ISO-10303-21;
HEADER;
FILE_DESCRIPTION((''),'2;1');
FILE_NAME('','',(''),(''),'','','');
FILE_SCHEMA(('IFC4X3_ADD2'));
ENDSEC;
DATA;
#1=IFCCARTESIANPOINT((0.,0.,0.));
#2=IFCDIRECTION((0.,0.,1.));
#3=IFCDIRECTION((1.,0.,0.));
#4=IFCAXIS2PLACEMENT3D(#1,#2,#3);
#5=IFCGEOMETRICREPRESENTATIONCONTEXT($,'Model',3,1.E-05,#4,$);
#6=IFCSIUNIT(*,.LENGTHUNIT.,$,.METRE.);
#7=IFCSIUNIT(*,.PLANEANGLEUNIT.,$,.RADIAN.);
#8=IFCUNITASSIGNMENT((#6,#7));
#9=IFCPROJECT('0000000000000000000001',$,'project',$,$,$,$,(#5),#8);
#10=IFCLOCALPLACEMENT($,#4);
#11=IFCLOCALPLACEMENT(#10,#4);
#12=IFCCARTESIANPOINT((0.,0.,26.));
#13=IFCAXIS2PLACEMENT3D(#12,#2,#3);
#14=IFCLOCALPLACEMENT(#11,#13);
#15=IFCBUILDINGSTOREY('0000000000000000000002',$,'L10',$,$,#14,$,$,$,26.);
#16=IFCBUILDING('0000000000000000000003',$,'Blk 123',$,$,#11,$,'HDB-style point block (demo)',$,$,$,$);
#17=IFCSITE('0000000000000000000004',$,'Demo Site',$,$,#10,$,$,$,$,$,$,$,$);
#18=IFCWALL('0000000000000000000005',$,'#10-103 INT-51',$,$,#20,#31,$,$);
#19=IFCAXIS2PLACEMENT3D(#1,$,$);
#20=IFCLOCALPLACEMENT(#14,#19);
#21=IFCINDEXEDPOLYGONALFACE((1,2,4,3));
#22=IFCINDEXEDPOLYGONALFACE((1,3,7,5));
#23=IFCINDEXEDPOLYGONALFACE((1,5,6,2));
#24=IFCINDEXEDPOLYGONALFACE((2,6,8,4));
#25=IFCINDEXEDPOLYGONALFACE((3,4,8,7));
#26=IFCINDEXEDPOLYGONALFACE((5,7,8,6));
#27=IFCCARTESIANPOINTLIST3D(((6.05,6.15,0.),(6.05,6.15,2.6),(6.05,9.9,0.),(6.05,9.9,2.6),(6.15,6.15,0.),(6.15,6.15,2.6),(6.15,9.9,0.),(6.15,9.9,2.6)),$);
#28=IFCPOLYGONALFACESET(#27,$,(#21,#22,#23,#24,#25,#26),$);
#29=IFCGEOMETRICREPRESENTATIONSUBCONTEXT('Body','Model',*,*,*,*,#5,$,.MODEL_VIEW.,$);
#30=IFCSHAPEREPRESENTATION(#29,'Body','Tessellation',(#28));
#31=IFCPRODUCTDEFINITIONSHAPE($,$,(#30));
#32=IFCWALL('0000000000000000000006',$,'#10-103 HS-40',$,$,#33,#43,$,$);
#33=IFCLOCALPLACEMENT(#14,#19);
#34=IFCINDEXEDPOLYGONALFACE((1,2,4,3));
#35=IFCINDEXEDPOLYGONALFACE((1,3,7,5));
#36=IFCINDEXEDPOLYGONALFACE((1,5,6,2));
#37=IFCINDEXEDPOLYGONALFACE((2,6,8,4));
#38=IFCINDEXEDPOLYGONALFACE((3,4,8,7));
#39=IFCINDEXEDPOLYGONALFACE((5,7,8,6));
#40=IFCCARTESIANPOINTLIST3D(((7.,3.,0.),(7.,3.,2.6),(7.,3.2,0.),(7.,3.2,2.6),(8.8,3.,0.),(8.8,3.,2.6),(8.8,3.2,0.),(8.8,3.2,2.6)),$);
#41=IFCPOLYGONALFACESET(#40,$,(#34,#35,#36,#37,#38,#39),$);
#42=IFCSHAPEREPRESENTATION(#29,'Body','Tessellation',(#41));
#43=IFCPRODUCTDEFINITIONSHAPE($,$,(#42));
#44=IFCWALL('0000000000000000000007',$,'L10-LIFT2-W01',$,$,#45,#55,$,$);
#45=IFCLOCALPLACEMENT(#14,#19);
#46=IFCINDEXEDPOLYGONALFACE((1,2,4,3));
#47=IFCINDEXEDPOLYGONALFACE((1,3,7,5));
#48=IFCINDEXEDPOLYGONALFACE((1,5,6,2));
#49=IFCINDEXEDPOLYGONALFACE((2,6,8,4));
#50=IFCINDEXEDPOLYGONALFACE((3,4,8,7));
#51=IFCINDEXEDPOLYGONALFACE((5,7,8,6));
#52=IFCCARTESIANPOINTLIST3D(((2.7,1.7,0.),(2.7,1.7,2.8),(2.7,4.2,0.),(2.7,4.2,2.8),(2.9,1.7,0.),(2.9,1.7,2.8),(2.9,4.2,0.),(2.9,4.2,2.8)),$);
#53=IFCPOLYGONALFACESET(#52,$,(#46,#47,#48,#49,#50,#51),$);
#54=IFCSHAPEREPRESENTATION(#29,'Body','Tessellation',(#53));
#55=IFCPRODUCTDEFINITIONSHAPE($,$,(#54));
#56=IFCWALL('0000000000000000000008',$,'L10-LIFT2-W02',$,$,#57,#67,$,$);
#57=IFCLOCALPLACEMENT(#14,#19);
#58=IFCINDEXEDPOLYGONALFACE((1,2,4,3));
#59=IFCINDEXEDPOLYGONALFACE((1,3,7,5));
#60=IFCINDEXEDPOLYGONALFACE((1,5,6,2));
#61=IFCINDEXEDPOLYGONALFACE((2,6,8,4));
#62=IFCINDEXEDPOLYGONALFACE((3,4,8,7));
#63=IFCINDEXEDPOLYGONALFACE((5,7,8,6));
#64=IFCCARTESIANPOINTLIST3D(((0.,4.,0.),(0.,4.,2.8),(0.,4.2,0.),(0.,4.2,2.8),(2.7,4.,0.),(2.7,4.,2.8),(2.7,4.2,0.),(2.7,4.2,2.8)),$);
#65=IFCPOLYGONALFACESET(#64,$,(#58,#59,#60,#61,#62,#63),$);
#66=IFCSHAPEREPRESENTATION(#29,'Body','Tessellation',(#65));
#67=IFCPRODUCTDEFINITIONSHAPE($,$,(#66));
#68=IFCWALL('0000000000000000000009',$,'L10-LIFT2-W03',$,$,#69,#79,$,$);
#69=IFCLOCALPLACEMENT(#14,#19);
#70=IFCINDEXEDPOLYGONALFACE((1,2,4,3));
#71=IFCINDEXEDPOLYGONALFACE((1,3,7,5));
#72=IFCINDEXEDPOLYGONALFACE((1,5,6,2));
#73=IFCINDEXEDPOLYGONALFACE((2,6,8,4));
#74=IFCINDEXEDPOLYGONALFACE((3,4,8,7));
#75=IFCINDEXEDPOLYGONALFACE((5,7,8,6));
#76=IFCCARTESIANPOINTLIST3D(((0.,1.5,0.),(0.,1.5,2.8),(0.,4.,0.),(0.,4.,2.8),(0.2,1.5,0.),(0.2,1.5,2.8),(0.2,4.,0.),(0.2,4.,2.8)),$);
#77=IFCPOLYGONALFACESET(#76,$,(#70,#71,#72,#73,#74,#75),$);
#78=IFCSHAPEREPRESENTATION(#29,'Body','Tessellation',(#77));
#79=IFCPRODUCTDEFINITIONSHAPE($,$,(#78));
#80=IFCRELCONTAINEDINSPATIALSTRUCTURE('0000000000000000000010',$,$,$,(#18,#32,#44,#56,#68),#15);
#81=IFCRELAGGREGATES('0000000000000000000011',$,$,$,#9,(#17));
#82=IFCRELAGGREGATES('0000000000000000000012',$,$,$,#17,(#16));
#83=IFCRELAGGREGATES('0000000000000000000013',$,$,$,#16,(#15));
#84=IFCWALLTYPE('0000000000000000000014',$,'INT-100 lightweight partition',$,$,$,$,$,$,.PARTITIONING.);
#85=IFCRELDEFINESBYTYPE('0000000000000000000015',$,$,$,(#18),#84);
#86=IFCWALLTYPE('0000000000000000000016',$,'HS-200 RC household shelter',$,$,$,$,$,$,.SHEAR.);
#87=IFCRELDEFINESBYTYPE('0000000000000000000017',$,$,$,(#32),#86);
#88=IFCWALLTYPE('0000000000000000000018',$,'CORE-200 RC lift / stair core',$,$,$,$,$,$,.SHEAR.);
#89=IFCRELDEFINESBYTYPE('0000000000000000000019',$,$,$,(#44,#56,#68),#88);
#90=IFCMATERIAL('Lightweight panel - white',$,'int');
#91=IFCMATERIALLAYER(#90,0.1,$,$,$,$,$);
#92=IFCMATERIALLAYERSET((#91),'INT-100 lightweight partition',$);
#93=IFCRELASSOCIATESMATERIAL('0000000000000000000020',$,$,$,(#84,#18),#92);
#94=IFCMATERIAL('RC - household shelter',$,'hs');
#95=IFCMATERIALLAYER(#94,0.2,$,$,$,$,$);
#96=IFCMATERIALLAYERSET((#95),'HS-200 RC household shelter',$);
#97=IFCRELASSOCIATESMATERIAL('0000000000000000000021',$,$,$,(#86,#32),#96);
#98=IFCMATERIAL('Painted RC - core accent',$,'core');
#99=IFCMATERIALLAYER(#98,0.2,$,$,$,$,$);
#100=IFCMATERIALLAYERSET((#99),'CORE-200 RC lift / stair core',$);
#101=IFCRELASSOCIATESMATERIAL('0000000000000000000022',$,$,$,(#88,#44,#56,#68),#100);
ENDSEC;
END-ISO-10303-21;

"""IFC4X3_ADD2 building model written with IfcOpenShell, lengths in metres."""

from ifc_helpers import new_model, si_unit, frame, origin_with_axes, place, context, subcontext, project, spatial, indexed_curve, outline, extrude, material, layer, layer_set, layer_usage, type_object, element, save


model = new_model("IFC4X3_ADD2")

# Units and contexts
model_context = context("Model", 3, precision=1e-05, world=origin_with_axes())
body_context = subcontext(model_context, "Body", "Model", "MODEL_VIEW")
ifc_project = project(units=[si_unit("LENGTHUNIT", "METRE"), si_unit("PLANEANGLEUNIT", "RADIAN")], contexts=[model_context])

# Site, building, storey
site_placement = place(None, origin_with_axes())
site = spatial("IfcSite", under=ifc_project, at=site_placement, Name="Demo Site")
building_placement = place(site_placement, origin_with_axes())
building = spatial("IfcBuilding", under=site, at=building_placement, Name="Blk 123", LongName="HDB-style point block (demo)")
storey_placement = place(building_placement, frame((0.0, 0.0, 26.0), z_axis=(0.0, 0.0, 1.0), x_axis=(1.0, 0.0, 0.0)))
storey = spatial("IfcBuildingStorey", under=building, at=storey_placement, Name="L10", Elevation=26.0)

# Shared definitions
ifc_material_1 = material(Name="Lightweight panel - white", Category="int")
ifc_layer_1 = layer(ifc_material_1, 0.1)
ifc_layer_set_1 = layer_set([ifc_layer_1], Name="INT-100 lightweight partition")
ifc_layer_usage_1 = layer_usage(ifc_layer_set_1, "AXIS2", "POSITIVE", -0.05)
wall_type_1 = type_object("IfcWallType", Name="INT-100 lightweight partition", PredefinedType="PARTITIONING", material=ifc_layer_set_1)

# Walls
wall_1_placement = place(storey_placement, frame((6.1, 6.15, 0.0), z_axis=(0.0, 0.0, 1.0), x_axis=(0.0, 1.0, 0.0)))
element("IfcWall", 1, at=wall_1_placement, inside=storey, type_object=wall_type_1, material=ifc_layer_usage_1, Name="#10-103 INT-51", context=body_context, shape_type="SweptSolid", body=[
    extrude(outline(indexed_curve([(0.0, 0.0), (0.0, 0.1), (3.75, 0.1), (3.75, 0.0), (0.0, 0.0)], self_intersect=False)), frame((0.0, -0.05, 0.0), z_axis=(0.0, 0.0, 1.0), x_axis=(1.0, 0.0, 0.0)), (0.0, 0.0, 1.0), 2.6),
])
ifc_material_2 = material(Name="RC - household shelter", Category="hs")
ifc_layer_2 = layer(ifc_material_2, 0.2)
ifc_layer_set_2 = layer_set([ifc_layer_2], Name="HS-200 RC household shelter")
ifc_layer_usage_2 = layer_usage(ifc_layer_set_2, "AXIS2", "POSITIVE", -0.1)
wall_type_2 = type_object("IfcWallType", Name="HS-200 RC household shelter", PredefinedType="SHEAR", material=ifc_layer_set_2)
wall_2_placement = place(storey_placement, frame((7.0, 3.1, 0.0), z_axis=(0.0, 0.0, 1.0), x_axis=(1.0, 0.0, 0.0)))
element("IfcWall", 2, at=wall_2_placement, inside=storey, type_object=wall_type_2, material=ifc_layer_usage_2, Name="#10-103 HS-40", context=body_context, shape_type="SweptSolid", body=[
    extrude(outline(indexed_curve([(0.0, 0.0), (0.0, 0.2), (1.8, 0.2), (1.8, 0.0), (0.0, 0.0)], self_intersect=False)), frame((0.0, -0.1, 0.0), z_axis=(0.0, 0.0, 1.0), x_axis=(1.0, 0.0, 0.0)), (0.0, 0.0, 1.0), 2.6),
])
ifc_material_3 = material(Name="Painted RC - core accent", Category="core")
ifc_layer_3 = layer(ifc_material_3, 0.2)
ifc_layer_set_3 = layer_set([ifc_layer_3], Name="CORE-200 RC lift / stair core")
ifc_layer_usage_3 = layer_usage(ifc_layer_set_3, "AXIS2", "POSITIVE", 0.0)
wall_type_3 = type_object("IfcWallType", Name="CORE-200 RC lift / stair core", PredefinedType="SHEAR", material=ifc_layer_set_3)
wall_3_placement = place(storey_placement, frame((2.9, 1.7, 0.0), z_axis=(0.0, 0.0, 1.0), x_axis=(0.0, 1.0, 0.0)))
element("IfcWall", 3, at=wall_3_placement, inside=storey, type_object=wall_type_3, material=ifc_layer_usage_3, Name="L10-LIFT2-W01", context=body_context, shape_type="SweptSolid", body=[
    extrude(outline(indexed_curve([(0.0, 0.0), (0.0, 0.2), (2.5, 0.2), (2.5, 0.0), (0.0, 0.0)], self_intersect=False)), origin_with_axes(), (0.0, 0.0, 1.0), 2.8),
])
wall_4_placement = place(storey_placement, frame((2.7, 4.2, 0.0), z_axis=(0.0, 0.0, 1.0), x_axis=(-1.0, 0.0, 0.0)))
element("IfcWall", 4, at=wall_4_placement, inside=storey, type_object=wall_type_3, material=ifc_layer_usage_3, Name="L10-LIFT2-W02", context=body_context, shape_type="SweptSolid", body=[
    extrude(outline(indexed_curve([(0.0, 0.0), (0.0, 0.2), (2.7, 0.2), (2.7, 0.0), (0.0, 0.0)], self_intersect=False)), origin_with_axes(), (0.0, 0.0, 1.0), 2.8),
])
wall_5_placement = place(storey_placement, frame((0.0, 4.0, 0.0), z_axis=(0.0, 0.0, 1.0), x_axis=(0.0, -1.0, 0.0)))
element("IfcWall", 5, at=wall_5_placement, inside=storey, type_object=wall_type_3, material=ifc_layer_usage_3, Name="L10-LIFT2-W03", context=body_context, shape_type="SweptSolid", body=[
    extrude(outline(indexed_curve([(0.0, 0.0), (0.0, 0.2), (2.5, 0.2), (2.5, 0.0), (0.0, 0.0)], self_intersect=False)), origin_with_axes(), (0.0, 0.0, 1.0), 2.8),
])

save(model, "model.ifc")
